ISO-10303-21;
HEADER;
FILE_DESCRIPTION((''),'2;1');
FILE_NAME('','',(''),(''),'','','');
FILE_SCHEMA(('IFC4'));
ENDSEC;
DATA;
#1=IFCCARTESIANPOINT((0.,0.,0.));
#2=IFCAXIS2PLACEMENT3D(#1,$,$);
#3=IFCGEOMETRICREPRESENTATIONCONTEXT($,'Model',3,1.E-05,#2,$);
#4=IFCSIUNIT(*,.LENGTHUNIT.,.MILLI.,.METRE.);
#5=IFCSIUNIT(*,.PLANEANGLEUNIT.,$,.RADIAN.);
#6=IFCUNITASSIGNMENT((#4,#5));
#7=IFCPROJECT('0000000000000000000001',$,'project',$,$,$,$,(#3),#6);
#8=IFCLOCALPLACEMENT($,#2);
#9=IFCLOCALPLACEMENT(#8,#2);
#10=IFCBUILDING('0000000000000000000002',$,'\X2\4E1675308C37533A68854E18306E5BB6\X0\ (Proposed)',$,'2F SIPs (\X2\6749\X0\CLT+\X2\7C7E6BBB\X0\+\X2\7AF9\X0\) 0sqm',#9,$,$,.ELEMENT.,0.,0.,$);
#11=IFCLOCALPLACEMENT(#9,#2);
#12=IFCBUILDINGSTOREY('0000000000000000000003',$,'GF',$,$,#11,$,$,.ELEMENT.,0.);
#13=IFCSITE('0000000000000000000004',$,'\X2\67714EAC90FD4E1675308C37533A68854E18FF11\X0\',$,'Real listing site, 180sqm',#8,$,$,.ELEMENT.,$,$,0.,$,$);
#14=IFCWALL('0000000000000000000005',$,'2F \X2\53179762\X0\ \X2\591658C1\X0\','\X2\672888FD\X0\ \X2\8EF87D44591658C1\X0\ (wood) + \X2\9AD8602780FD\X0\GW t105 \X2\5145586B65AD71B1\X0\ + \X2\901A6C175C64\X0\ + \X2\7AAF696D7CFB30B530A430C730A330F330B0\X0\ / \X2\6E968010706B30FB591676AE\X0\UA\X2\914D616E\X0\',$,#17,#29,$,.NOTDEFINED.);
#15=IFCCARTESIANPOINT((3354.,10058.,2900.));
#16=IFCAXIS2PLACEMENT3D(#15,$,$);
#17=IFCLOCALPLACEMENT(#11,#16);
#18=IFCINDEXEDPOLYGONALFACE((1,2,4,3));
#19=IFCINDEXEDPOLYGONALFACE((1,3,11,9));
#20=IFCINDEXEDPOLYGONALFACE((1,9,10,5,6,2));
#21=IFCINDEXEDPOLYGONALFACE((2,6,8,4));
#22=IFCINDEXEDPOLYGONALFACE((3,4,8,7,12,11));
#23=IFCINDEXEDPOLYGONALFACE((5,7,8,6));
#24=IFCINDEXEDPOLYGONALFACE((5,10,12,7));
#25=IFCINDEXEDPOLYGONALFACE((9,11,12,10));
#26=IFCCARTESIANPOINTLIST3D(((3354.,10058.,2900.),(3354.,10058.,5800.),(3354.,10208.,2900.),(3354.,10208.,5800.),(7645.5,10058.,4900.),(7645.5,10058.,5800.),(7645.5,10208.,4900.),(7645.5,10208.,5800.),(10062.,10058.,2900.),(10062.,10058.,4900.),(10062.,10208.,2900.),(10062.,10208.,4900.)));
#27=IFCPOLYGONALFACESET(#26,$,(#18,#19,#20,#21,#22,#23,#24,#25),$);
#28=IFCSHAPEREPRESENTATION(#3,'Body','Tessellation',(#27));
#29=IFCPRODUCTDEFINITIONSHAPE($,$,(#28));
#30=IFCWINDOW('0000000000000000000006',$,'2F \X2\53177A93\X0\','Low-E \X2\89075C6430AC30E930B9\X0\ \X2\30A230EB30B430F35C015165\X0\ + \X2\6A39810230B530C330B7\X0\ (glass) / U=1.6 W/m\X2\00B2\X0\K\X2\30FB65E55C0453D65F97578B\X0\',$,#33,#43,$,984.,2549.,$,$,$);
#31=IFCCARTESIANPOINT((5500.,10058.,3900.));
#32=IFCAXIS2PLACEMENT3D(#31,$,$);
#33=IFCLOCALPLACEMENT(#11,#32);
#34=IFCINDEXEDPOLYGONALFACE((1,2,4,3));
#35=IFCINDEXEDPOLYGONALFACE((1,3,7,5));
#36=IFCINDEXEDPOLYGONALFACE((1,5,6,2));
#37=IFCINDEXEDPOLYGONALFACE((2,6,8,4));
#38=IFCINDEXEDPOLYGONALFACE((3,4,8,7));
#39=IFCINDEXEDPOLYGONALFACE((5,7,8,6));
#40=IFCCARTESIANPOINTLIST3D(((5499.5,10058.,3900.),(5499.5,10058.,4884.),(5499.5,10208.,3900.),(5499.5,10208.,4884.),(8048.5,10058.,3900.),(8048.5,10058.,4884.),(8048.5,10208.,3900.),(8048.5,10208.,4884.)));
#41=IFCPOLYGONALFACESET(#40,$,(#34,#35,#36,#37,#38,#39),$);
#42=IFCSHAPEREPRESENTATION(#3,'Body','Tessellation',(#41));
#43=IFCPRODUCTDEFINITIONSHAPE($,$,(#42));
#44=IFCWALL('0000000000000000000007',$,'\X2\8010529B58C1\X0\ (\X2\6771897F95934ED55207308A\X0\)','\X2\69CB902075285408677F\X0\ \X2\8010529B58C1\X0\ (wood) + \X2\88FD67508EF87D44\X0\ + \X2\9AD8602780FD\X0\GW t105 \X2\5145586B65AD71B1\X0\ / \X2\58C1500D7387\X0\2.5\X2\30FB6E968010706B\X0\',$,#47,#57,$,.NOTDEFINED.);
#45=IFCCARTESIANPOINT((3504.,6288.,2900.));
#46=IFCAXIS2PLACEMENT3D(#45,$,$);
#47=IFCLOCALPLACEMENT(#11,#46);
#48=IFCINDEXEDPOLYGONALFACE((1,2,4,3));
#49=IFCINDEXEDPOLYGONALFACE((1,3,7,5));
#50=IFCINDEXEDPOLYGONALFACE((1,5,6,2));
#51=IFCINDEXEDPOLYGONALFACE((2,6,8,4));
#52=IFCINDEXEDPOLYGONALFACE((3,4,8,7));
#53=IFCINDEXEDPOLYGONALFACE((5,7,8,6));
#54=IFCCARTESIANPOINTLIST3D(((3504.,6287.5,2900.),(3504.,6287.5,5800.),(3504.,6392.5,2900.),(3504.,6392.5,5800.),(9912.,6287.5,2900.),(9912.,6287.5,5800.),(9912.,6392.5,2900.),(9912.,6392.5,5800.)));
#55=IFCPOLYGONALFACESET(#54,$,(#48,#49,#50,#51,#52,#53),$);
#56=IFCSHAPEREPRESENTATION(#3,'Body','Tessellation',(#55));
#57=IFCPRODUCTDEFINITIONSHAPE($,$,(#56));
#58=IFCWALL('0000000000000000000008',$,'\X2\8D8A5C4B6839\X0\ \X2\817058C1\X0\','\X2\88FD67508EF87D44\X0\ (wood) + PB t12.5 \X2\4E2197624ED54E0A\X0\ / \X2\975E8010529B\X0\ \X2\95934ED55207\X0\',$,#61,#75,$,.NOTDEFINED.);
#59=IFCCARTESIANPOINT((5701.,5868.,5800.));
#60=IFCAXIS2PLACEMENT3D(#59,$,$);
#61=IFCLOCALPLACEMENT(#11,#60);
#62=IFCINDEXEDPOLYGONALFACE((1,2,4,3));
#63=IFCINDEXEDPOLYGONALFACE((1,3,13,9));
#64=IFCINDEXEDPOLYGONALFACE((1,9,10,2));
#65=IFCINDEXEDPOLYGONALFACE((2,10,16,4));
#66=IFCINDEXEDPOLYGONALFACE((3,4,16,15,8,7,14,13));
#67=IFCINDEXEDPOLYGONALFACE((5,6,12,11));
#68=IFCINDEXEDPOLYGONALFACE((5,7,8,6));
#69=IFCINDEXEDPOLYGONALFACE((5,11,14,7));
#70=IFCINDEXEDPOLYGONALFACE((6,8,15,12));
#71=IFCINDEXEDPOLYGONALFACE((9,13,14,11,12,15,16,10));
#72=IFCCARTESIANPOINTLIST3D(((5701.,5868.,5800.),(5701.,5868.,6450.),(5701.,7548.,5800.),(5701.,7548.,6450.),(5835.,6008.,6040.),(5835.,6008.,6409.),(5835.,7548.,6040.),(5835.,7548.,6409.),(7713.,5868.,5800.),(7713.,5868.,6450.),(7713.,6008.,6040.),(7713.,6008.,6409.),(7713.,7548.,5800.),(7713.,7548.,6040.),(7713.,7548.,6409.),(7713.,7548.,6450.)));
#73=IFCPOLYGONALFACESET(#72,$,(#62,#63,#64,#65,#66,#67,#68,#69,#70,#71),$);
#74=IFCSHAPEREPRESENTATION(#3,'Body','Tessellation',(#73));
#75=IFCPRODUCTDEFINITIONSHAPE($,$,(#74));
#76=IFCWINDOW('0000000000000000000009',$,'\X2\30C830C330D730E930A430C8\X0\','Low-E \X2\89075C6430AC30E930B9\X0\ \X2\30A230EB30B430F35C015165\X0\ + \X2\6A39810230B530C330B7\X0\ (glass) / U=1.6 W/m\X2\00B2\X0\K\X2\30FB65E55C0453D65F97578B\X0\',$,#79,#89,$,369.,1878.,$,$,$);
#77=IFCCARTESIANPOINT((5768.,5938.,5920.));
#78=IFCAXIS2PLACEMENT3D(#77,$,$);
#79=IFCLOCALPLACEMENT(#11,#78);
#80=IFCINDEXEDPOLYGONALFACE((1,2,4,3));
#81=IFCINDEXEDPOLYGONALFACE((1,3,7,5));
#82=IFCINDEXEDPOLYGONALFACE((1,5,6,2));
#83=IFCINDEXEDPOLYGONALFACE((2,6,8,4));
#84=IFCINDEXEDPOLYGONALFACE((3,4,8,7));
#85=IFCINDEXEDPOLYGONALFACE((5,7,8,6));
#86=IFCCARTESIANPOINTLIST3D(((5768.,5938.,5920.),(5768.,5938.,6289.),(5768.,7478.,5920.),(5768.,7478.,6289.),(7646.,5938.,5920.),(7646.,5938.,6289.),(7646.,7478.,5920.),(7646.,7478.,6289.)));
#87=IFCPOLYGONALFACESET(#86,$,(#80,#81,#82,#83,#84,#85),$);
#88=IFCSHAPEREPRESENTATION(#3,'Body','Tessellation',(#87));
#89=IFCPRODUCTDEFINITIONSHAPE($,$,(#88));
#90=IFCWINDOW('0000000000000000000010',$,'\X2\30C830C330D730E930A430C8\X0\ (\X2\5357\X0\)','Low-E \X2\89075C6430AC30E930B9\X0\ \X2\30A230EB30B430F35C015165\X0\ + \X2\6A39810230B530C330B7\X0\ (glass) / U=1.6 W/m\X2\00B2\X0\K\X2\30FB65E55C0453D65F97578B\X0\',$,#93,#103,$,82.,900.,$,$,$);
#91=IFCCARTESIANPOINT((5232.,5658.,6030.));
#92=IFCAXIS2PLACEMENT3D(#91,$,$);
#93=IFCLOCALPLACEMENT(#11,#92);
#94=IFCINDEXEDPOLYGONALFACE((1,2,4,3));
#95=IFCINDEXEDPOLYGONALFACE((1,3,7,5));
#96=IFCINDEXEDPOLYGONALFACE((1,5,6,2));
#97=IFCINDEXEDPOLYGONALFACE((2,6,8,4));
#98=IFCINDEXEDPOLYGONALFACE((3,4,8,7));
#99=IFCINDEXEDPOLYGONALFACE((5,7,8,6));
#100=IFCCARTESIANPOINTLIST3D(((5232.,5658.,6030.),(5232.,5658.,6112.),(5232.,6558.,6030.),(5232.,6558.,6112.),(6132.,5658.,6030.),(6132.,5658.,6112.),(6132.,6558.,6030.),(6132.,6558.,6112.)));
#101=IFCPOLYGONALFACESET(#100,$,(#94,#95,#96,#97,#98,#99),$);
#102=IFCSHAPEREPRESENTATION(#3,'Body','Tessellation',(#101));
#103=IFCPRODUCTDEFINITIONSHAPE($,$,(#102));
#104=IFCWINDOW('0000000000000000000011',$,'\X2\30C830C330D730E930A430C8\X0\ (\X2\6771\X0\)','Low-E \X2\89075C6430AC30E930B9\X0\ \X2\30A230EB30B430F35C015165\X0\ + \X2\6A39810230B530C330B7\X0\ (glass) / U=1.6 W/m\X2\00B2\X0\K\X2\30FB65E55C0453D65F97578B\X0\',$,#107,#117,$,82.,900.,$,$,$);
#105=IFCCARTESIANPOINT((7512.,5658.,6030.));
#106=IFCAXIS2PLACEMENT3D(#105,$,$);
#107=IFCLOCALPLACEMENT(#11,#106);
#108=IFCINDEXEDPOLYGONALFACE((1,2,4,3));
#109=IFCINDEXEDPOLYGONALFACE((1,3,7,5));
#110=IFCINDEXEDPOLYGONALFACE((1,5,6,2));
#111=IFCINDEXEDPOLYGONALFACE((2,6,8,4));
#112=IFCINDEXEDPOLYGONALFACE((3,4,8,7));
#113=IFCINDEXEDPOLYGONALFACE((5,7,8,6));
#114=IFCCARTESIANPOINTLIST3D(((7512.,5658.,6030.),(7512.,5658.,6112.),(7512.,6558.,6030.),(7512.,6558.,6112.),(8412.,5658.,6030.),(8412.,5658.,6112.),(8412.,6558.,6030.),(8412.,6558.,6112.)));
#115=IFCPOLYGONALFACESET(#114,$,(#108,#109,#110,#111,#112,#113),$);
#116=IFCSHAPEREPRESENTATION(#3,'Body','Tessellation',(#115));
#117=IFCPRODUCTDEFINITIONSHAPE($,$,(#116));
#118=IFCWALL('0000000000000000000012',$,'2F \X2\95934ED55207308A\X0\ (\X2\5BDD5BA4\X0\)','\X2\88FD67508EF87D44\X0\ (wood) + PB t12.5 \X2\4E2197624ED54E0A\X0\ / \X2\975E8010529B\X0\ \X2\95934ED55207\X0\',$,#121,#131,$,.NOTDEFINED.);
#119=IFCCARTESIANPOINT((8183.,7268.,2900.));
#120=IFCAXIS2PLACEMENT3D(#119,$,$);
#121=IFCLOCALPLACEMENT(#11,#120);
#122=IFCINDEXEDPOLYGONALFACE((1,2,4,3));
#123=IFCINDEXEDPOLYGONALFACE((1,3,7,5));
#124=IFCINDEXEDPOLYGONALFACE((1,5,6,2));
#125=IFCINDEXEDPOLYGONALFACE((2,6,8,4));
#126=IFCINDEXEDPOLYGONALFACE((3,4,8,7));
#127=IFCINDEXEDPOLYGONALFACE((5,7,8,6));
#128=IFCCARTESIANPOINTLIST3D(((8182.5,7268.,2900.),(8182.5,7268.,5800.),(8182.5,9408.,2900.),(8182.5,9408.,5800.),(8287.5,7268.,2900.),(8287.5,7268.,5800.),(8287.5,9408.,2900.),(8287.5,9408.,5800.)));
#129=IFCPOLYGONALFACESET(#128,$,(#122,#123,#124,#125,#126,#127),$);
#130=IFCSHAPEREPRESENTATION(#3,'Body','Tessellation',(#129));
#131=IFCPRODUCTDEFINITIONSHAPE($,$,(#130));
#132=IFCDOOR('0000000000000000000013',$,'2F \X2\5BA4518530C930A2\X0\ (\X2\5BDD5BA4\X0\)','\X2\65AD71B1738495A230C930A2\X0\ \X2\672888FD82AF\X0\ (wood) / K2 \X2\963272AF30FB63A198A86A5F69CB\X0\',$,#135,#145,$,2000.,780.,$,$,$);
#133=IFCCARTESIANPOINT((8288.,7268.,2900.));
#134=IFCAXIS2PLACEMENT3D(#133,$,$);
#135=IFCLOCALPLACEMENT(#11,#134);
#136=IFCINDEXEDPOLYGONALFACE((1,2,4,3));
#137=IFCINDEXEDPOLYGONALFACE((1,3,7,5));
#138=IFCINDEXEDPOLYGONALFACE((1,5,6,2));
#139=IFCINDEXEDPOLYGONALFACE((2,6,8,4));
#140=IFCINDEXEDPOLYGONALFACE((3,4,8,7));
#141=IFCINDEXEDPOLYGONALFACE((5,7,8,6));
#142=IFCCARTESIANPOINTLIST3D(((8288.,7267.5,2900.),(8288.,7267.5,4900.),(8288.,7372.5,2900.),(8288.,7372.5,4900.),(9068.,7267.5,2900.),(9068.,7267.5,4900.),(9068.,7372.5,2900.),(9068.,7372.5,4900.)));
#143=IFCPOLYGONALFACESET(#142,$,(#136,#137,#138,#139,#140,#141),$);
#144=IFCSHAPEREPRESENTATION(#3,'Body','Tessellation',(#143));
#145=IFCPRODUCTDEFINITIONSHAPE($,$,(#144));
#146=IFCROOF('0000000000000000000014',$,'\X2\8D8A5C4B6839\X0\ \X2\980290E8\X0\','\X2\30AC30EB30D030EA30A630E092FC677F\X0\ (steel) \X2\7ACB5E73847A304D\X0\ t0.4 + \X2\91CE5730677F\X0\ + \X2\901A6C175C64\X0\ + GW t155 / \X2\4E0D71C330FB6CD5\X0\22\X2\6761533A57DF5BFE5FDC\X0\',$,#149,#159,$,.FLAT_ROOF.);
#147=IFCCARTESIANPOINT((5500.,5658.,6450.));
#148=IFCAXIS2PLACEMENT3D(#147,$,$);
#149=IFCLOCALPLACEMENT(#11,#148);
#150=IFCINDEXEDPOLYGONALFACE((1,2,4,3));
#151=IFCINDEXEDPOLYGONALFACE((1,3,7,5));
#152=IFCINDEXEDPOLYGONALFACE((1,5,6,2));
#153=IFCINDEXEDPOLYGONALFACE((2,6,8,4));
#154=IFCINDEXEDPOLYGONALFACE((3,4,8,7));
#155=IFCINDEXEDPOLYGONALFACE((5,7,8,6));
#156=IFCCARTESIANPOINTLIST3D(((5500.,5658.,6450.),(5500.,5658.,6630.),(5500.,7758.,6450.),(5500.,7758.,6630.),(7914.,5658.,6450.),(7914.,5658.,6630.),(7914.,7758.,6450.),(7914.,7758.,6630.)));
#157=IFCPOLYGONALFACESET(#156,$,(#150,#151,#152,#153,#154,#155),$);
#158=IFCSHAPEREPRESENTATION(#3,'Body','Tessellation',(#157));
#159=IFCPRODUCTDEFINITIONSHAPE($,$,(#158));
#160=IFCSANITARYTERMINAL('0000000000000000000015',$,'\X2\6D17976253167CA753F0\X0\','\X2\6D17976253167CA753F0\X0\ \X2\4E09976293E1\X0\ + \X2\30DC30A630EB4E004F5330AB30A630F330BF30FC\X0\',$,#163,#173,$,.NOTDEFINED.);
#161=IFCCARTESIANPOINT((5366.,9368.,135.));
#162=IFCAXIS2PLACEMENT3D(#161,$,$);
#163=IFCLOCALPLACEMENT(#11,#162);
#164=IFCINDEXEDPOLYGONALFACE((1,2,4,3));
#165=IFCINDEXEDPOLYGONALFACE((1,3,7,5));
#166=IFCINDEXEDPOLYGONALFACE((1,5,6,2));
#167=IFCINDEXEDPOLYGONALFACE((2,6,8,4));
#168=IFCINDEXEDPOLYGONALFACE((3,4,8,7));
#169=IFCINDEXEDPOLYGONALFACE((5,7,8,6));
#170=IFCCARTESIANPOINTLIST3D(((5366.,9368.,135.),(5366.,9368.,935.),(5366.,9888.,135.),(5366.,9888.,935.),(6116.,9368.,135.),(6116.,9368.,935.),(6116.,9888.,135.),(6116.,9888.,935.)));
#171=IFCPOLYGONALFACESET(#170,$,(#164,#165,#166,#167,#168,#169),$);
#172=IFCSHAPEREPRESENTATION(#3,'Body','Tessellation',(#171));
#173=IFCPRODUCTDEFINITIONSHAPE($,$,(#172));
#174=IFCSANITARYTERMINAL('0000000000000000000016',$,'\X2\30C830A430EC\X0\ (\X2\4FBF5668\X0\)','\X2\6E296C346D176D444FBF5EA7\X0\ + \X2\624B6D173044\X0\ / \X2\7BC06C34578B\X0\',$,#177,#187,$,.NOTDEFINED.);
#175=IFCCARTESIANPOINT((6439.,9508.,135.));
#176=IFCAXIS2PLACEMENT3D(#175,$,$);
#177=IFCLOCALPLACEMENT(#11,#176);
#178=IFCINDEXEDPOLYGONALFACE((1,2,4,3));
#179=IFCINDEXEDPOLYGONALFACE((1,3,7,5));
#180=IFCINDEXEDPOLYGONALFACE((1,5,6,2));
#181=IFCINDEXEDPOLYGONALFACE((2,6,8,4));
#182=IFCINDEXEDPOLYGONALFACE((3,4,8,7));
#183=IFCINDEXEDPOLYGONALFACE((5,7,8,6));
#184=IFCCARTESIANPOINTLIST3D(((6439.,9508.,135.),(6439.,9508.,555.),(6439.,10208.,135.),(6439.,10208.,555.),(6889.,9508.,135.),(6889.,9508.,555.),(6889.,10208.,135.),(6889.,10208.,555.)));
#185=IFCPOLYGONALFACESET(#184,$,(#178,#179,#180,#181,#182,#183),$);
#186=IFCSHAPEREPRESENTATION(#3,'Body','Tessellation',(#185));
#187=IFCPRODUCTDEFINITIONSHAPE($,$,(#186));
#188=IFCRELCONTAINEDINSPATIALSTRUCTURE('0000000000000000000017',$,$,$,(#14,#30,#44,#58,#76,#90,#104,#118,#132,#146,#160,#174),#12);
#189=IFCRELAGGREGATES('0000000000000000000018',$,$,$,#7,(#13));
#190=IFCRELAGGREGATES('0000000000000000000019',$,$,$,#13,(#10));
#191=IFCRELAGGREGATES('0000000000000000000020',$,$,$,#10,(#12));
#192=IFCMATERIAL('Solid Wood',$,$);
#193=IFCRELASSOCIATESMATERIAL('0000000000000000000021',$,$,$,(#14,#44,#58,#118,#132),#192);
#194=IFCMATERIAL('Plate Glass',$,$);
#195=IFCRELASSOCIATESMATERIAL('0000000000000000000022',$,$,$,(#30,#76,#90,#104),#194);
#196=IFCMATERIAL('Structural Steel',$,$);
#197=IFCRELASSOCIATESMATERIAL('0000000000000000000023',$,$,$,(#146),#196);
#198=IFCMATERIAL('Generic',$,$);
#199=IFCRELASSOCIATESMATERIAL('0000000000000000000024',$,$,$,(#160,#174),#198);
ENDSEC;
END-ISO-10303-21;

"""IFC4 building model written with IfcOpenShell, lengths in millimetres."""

from ifc_helpers import new_model, si_unit, frame, frame_2d, origin, place, context, project, spatial, rectangle, extrude, material, element, fill, save


model = new_model("IFC4")

# Units and contexts
model_context = context("Model", 3, precision=1e-05, world=origin())
ifc_project = project(units=[si_unit("LENGTHUNIT", "METRE", prefix="MILLI"), si_unit("PLANEANGLEUNIT", "RADIAN")], contexts=[model_context])

# Site, building, storey
site_placement = place(None, origin())
site = spatial("IfcSite", under=ifc_project, at=site_placement, Name="東京都世田谷区梅丘１", ObjectType="Real listing site, 180sqm", CompositionType="ELEMENT", RefElevation=0.0)
building_placement = place(site_placement, origin())
building = spatial("IfcBuilding", under=site, at=building_placement, Name="世田谷区梅丘の家 (Proposed)", ObjectType="2F SIPs (杉CLT+籾殻+竹) 0sqm", CompositionType="ELEMENT", ElevationOfRefHeight=0.0, ElevationOfTerrain=0.0)
storey_placement = place(building_placement, origin())
storey = spatial("IfcBuildingStorey", under=building, at=storey_placement, Name="GF", CompositionType="ELEMENT", Elevation=0.0)

# Wall, opening, window
ifc_material_1 = material(Name="Solid Wood")
wall_1_placement = place(storey_placement, frame((3354.0, 10058.0, 2900.0)))
wall_1 = element("IfcWall", 1, at=wall_1_placement, inside=storey, material=ifc_material_1, Name="2F 北面 外壁", Description="木製 軸組外壁 (wood) + 高性能GW t105 充填断熱 + 通気層 + 窯業系サイディング / 準耐火・外皮UA配慮", PredefinedType="NOTDEFINED", context=model_context, shape_type="SweptSolid", body=[
    extrude(rectangle(XDim=6708.0, YDim=150.0, at=frame_2d((3354.0, 75.0))), frame((3354.0, 10058.0, 2900.0)), (0.0, 0.0, 1.0), 2900.0),
])
opening_1_placement = place(storey_placement, frame((5500.0, 10058.0, 3900.0)))
opening_1 = element("IfcOpeningElement", 2, at=opening_1_placement, cuts=wall_1, PredefinedType="NOTDEFINED", context=model_context, shape_type="SweptSolid", body=[
    extrude(rectangle(XDim=2549.0, YDim=150.0, at=frame_2d((1274.0, 75.0))), frame((5500.0, 10058.0, 3900.0)), (0.0, 0.0, 1.0), 984.0),
])
ifc_material_2 = material(Name="Plate Glass")
window_1_placement = place(storey_placement, frame((5500.0, 10058.0, 3900.0)))
window_1 = element("IfcWindow", 3, at=window_1_placement, inside=storey, material=ifc_material_2, Name="2F 北窓", Description="Low-E 複層ガラス アルゴン封入 + 樹脂サッシ (glass) / U=1.6 W/m²K・日射取得型", OverallHeight=984.0, OverallWidth=2549.0, context=model_context, shape_type="SweptSolid", body=[
    extrude(rectangle(XDim=2549.0, YDim=150.0, at=frame_2d((1274.0, 75.0))), frame((5500.0, 10058.0, 3900.0)), (0.0, 0.0, 1.0), 984.0),
])
fill(opening_1, window_1)

# Wall
wall_2_placement = place(storey_placement, frame((3504.0, 6288.0, 2900.0)))
element("IfcWall", 4, at=wall_2_placement, inside=storey, material=ifc_material_1, Name="耐力壁 (東西間仕切り)", Description="構造用合板 耐力壁 (wood) + 製材軸組 + 高性能GW t105 充填断熱 / 壁倍率2.5・準耐火", PredefinedType="NOTDEFINED", context=model_context, shape_type="SweptSolid", body=[
    extrude(rectangle(XDim=6408.0, YDim=105.0, at=frame_2d((3204.0, 52.0))), frame((3504.0, 6288.0, 2900.0)), (0.0, 0.0, 1.0), 2900.0),
])

# Wall, openings, windows
wall_3_placement = place(storey_placement, frame((5701.0, 5868.0, 5800.0)))
wall_3 = element("IfcWall", 5, at=wall_3_placement, inside=storey, material=ifc_material_1, Name="越屋根 腰壁", Description="製材軸組 (wood) + PB t12.5 両面仕上 / 非耐力 間仕切", PredefinedType="NOTDEFINED", context=model_context, shape_type="SweptSolid", body=[
    extrude(rectangle(XDim=2012.0, YDim=1680.0, at=frame_2d((1006.0, 840.0))), frame((5701.0, 5868.0, 5800.0)), (0.0, 0.0, 1.0), 650.0),
])
opening_2_placement = place(storey_placement, frame((5768.0, 5938.0, 5920.0)))
opening_2 = element("IfcOpeningElement", 6, at=opening_2_placement, cuts=wall_3, PredefinedType="NOTDEFINED", context=model_context, shape_type="SweptSolid", body=[
    extrude(rectangle(XDim=1878.0, YDim=1540.0, at=frame_2d((939.0, 770.0))), frame((5768.0, 5938.0, 5920.0)), (0.0, 0.0, 1.0), 369.0),
])
opening_3_placement = place(storey_placement, frame((5232.0, 5658.0, 6030.0)))
opening_3 = element("IfcOpeningElement", 7, at=opening_3_placement, cuts=wall_3, PredefinedType="NOTDEFINED", context=model_context, shape_type="SweptSolid", body=[
    extrude(rectangle(XDim=900.0, YDim=900.0, at=frame_2d((450.0, 450.0))), frame((5232.0, 5658.0, 6030.0)), (0.0, 0.0, 1.0), 82.0),
])
opening_4_placement = place(storey_placement, frame((7512.0, 5658.0, 6030.0)))
opening_4 = element("IfcOpeningElement", 8, at=opening_4_placement, cuts=wall_3, PredefinedType="NOTDEFINED", context=model_context, shape_type="SweptSolid", body=[
    extrude(rectangle(XDim=900.0, YDim=900.0, at=frame_2d((450.0, 450.0))), frame((7512.0, 5658.0, 6030.0)), (0.0, 0.0, 1.0), 82.0),
])
window_2_placement = place(storey_placement, frame((5768.0, 5938.0, 5920.0)))
window_2 = element("IfcWindow", 9, at=window_2_placement, inside=storey, material=ifc_material_2, Name="トップライト", Description="Low-E 複層ガラス アルゴン封入 + 樹脂サッシ (glass) / U=1.6 W/m²K・日射取得型", OverallHeight=369.0, OverallWidth=1878.0, context=model_context, shape_type="SweptSolid", body=[
    extrude(rectangle(XDim=1878.0, YDim=1540.0, at=frame_2d((939.0, 770.0))), frame((5768.0, 5938.0, 5920.0)), (0.0, 0.0, 1.0), 369.0),
])
fill(opening_2, window_2)
window_3_placement = place(storey_placement, frame((5232.0, 5658.0, 6030.0)))
window_3 = element("IfcWindow", 10, at=window_3_placement, inside=storey, material=ifc_material_2, Name="トップライト (南)", Description="Low-E 複層ガラス アルゴン封入 + 樹脂サッシ (glass) / U=1.6 W/m²K・日射取得型", OverallHeight=82.0, OverallWidth=900.0, context=model_context, shape_type="SweptSolid", body=[
    extrude(rectangle(XDim=900.0, YDim=900.0, at=frame_2d((450.0, 450.0))), frame((5232.0, 5658.0, 6030.0)), (0.0, 0.0, 1.0), 82.0),
])
fill(opening_3, window_3)
window_4_placement = place(storey_placement, frame((7512.0, 5658.0, 6030.0)))
window_4 = element("IfcWindow", 11, at=window_4_placement, inside=storey, material=ifc_material_2, Name="トップライト (東)", Description="Low-E 複層ガラス アルゴン封入 + 樹脂サッシ (glass) / U=1.6 W/m²K・日射取得型", OverallHeight=82.0, OverallWidth=900.0, context=model_context, shape_type="SweptSolid", body=[
    extrude(rectangle(XDim=900.0, YDim=900.0, at=frame_2d((450.0, 450.0))), frame((7512.0, 5658.0, 6030.0)), (0.0, 0.0, 1.0), 82.0),
])
fill(opening_4, window_4)

# Wall
wall_4_placement = place(storey_placement, frame((8183.0, 7268.0, 2900.0)))
element("IfcWall", 12, at=wall_4_placement, inside=storey, material=ifc_material_1, Name="2F 間仕切り (寝室)", Description="製材軸組 (wood) + PB t12.5 両面仕上 / 非耐力 間仕切", PredefinedType="NOTDEFINED", context=model_context, shape_type="SweptSolid", body=[
    extrude(rectangle(XDim=105.0, YDim=2140.0, at=frame_2d((52.0, 1070.0))), frame((8183.0, 7268.0, 2900.0)), (0.0, 0.0, 1.0), 2900.0),
])

# Door
door_placement = place(storey_placement, frame((8288.0, 7268.0, 2900.0)))
element("IfcDoor", 13, at=door_placement, inside=storey, material=ifc_material_1, Name="2F 室内ドア (寝室)", Description="断熱玄関ドア 木製芯 (wood) / K2 防犯・採風機構", OverallHeight=2000.0, OverallWidth=780.0, context=model_context, shape_type="SweptSolid", body=[
    extrude(rectangle(XDim=780.0, YDim=105.0, at=frame_2d((390.0, 52.0))), frame((8288.0, 7268.0, 2900.0)), (0.0, 0.0, 1.0), 2000.0),
])

# Roof
ifc_material_3 = material(Name="Structural Steel")
roof_placement = place(storey_placement, frame((5500.0, 5658.0, 6450.0)))
element("IfcRoof", 14, at=roof_placement, inside=storey, material=ifc_material_3, Name="越屋根 頂部", Description="ガルバリウム鋼板 (steel) 立平葺き t0.4 + 野地板 + 通気層 + GW t155 / 不燃・法22条区域対応", PredefinedType="FLAT_ROOF", context=model_context, shape_type="SweptSolid", body=[
    extrude(rectangle(XDim=2414.0, YDim=2100.0, at=frame_2d((1207.0, 1050.0))), frame((5500.0, 5658.0, 6450.0)), (0.0, 0.0, 1.0), 180.0),
])

# Sanitary terminals
ifc_material_4 = material(Name="Generic")
sanitary_terminal_1_placement = place(storey_placement, frame((5366.0, 9368.0, 135.0)))
element("IfcSanitaryTerminal", 15, at=sanitary_terminal_1_placement, inside=storey, material=ifc_material_4, Name="洗面化粧台", Description="洗面化粧台 三面鏡 + ボウル一体カウンター", PredefinedType="NOTDEFINED", context=model_context, shape_type="SweptSolid", body=[
    extrude(rectangle(XDim=750.0, YDim=520.0, at=frame_2d((375.0, 260.0))), frame((5366.0, 9368.0, 135.0)), (0.0, 0.0, 1.0), 800.0),
])
sanitary_terminal_2_placement = place(storey_placement, frame((6439.0, 9508.0, 135.0)))
element("IfcSanitaryTerminal", 16, at=sanitary_terminal_2_placement, inside=storey, material=ifc_material_4, Name="トイレ (便器)", Description="温水洗浄便座 + 手洗い / 節水型", PredefinedType="NOTDEFINED", context=model_context, shape_type="SweptSolid", body=[
    extrude(rectangle(XDim=450.0, YDim=700.0, at=frame_2d((225.0, 350.0))), frame((6439.0, 9508.0, 135.0)), (0.0, 0.0, 1.0), 420.0),
])

save(model, "model.ifc")
